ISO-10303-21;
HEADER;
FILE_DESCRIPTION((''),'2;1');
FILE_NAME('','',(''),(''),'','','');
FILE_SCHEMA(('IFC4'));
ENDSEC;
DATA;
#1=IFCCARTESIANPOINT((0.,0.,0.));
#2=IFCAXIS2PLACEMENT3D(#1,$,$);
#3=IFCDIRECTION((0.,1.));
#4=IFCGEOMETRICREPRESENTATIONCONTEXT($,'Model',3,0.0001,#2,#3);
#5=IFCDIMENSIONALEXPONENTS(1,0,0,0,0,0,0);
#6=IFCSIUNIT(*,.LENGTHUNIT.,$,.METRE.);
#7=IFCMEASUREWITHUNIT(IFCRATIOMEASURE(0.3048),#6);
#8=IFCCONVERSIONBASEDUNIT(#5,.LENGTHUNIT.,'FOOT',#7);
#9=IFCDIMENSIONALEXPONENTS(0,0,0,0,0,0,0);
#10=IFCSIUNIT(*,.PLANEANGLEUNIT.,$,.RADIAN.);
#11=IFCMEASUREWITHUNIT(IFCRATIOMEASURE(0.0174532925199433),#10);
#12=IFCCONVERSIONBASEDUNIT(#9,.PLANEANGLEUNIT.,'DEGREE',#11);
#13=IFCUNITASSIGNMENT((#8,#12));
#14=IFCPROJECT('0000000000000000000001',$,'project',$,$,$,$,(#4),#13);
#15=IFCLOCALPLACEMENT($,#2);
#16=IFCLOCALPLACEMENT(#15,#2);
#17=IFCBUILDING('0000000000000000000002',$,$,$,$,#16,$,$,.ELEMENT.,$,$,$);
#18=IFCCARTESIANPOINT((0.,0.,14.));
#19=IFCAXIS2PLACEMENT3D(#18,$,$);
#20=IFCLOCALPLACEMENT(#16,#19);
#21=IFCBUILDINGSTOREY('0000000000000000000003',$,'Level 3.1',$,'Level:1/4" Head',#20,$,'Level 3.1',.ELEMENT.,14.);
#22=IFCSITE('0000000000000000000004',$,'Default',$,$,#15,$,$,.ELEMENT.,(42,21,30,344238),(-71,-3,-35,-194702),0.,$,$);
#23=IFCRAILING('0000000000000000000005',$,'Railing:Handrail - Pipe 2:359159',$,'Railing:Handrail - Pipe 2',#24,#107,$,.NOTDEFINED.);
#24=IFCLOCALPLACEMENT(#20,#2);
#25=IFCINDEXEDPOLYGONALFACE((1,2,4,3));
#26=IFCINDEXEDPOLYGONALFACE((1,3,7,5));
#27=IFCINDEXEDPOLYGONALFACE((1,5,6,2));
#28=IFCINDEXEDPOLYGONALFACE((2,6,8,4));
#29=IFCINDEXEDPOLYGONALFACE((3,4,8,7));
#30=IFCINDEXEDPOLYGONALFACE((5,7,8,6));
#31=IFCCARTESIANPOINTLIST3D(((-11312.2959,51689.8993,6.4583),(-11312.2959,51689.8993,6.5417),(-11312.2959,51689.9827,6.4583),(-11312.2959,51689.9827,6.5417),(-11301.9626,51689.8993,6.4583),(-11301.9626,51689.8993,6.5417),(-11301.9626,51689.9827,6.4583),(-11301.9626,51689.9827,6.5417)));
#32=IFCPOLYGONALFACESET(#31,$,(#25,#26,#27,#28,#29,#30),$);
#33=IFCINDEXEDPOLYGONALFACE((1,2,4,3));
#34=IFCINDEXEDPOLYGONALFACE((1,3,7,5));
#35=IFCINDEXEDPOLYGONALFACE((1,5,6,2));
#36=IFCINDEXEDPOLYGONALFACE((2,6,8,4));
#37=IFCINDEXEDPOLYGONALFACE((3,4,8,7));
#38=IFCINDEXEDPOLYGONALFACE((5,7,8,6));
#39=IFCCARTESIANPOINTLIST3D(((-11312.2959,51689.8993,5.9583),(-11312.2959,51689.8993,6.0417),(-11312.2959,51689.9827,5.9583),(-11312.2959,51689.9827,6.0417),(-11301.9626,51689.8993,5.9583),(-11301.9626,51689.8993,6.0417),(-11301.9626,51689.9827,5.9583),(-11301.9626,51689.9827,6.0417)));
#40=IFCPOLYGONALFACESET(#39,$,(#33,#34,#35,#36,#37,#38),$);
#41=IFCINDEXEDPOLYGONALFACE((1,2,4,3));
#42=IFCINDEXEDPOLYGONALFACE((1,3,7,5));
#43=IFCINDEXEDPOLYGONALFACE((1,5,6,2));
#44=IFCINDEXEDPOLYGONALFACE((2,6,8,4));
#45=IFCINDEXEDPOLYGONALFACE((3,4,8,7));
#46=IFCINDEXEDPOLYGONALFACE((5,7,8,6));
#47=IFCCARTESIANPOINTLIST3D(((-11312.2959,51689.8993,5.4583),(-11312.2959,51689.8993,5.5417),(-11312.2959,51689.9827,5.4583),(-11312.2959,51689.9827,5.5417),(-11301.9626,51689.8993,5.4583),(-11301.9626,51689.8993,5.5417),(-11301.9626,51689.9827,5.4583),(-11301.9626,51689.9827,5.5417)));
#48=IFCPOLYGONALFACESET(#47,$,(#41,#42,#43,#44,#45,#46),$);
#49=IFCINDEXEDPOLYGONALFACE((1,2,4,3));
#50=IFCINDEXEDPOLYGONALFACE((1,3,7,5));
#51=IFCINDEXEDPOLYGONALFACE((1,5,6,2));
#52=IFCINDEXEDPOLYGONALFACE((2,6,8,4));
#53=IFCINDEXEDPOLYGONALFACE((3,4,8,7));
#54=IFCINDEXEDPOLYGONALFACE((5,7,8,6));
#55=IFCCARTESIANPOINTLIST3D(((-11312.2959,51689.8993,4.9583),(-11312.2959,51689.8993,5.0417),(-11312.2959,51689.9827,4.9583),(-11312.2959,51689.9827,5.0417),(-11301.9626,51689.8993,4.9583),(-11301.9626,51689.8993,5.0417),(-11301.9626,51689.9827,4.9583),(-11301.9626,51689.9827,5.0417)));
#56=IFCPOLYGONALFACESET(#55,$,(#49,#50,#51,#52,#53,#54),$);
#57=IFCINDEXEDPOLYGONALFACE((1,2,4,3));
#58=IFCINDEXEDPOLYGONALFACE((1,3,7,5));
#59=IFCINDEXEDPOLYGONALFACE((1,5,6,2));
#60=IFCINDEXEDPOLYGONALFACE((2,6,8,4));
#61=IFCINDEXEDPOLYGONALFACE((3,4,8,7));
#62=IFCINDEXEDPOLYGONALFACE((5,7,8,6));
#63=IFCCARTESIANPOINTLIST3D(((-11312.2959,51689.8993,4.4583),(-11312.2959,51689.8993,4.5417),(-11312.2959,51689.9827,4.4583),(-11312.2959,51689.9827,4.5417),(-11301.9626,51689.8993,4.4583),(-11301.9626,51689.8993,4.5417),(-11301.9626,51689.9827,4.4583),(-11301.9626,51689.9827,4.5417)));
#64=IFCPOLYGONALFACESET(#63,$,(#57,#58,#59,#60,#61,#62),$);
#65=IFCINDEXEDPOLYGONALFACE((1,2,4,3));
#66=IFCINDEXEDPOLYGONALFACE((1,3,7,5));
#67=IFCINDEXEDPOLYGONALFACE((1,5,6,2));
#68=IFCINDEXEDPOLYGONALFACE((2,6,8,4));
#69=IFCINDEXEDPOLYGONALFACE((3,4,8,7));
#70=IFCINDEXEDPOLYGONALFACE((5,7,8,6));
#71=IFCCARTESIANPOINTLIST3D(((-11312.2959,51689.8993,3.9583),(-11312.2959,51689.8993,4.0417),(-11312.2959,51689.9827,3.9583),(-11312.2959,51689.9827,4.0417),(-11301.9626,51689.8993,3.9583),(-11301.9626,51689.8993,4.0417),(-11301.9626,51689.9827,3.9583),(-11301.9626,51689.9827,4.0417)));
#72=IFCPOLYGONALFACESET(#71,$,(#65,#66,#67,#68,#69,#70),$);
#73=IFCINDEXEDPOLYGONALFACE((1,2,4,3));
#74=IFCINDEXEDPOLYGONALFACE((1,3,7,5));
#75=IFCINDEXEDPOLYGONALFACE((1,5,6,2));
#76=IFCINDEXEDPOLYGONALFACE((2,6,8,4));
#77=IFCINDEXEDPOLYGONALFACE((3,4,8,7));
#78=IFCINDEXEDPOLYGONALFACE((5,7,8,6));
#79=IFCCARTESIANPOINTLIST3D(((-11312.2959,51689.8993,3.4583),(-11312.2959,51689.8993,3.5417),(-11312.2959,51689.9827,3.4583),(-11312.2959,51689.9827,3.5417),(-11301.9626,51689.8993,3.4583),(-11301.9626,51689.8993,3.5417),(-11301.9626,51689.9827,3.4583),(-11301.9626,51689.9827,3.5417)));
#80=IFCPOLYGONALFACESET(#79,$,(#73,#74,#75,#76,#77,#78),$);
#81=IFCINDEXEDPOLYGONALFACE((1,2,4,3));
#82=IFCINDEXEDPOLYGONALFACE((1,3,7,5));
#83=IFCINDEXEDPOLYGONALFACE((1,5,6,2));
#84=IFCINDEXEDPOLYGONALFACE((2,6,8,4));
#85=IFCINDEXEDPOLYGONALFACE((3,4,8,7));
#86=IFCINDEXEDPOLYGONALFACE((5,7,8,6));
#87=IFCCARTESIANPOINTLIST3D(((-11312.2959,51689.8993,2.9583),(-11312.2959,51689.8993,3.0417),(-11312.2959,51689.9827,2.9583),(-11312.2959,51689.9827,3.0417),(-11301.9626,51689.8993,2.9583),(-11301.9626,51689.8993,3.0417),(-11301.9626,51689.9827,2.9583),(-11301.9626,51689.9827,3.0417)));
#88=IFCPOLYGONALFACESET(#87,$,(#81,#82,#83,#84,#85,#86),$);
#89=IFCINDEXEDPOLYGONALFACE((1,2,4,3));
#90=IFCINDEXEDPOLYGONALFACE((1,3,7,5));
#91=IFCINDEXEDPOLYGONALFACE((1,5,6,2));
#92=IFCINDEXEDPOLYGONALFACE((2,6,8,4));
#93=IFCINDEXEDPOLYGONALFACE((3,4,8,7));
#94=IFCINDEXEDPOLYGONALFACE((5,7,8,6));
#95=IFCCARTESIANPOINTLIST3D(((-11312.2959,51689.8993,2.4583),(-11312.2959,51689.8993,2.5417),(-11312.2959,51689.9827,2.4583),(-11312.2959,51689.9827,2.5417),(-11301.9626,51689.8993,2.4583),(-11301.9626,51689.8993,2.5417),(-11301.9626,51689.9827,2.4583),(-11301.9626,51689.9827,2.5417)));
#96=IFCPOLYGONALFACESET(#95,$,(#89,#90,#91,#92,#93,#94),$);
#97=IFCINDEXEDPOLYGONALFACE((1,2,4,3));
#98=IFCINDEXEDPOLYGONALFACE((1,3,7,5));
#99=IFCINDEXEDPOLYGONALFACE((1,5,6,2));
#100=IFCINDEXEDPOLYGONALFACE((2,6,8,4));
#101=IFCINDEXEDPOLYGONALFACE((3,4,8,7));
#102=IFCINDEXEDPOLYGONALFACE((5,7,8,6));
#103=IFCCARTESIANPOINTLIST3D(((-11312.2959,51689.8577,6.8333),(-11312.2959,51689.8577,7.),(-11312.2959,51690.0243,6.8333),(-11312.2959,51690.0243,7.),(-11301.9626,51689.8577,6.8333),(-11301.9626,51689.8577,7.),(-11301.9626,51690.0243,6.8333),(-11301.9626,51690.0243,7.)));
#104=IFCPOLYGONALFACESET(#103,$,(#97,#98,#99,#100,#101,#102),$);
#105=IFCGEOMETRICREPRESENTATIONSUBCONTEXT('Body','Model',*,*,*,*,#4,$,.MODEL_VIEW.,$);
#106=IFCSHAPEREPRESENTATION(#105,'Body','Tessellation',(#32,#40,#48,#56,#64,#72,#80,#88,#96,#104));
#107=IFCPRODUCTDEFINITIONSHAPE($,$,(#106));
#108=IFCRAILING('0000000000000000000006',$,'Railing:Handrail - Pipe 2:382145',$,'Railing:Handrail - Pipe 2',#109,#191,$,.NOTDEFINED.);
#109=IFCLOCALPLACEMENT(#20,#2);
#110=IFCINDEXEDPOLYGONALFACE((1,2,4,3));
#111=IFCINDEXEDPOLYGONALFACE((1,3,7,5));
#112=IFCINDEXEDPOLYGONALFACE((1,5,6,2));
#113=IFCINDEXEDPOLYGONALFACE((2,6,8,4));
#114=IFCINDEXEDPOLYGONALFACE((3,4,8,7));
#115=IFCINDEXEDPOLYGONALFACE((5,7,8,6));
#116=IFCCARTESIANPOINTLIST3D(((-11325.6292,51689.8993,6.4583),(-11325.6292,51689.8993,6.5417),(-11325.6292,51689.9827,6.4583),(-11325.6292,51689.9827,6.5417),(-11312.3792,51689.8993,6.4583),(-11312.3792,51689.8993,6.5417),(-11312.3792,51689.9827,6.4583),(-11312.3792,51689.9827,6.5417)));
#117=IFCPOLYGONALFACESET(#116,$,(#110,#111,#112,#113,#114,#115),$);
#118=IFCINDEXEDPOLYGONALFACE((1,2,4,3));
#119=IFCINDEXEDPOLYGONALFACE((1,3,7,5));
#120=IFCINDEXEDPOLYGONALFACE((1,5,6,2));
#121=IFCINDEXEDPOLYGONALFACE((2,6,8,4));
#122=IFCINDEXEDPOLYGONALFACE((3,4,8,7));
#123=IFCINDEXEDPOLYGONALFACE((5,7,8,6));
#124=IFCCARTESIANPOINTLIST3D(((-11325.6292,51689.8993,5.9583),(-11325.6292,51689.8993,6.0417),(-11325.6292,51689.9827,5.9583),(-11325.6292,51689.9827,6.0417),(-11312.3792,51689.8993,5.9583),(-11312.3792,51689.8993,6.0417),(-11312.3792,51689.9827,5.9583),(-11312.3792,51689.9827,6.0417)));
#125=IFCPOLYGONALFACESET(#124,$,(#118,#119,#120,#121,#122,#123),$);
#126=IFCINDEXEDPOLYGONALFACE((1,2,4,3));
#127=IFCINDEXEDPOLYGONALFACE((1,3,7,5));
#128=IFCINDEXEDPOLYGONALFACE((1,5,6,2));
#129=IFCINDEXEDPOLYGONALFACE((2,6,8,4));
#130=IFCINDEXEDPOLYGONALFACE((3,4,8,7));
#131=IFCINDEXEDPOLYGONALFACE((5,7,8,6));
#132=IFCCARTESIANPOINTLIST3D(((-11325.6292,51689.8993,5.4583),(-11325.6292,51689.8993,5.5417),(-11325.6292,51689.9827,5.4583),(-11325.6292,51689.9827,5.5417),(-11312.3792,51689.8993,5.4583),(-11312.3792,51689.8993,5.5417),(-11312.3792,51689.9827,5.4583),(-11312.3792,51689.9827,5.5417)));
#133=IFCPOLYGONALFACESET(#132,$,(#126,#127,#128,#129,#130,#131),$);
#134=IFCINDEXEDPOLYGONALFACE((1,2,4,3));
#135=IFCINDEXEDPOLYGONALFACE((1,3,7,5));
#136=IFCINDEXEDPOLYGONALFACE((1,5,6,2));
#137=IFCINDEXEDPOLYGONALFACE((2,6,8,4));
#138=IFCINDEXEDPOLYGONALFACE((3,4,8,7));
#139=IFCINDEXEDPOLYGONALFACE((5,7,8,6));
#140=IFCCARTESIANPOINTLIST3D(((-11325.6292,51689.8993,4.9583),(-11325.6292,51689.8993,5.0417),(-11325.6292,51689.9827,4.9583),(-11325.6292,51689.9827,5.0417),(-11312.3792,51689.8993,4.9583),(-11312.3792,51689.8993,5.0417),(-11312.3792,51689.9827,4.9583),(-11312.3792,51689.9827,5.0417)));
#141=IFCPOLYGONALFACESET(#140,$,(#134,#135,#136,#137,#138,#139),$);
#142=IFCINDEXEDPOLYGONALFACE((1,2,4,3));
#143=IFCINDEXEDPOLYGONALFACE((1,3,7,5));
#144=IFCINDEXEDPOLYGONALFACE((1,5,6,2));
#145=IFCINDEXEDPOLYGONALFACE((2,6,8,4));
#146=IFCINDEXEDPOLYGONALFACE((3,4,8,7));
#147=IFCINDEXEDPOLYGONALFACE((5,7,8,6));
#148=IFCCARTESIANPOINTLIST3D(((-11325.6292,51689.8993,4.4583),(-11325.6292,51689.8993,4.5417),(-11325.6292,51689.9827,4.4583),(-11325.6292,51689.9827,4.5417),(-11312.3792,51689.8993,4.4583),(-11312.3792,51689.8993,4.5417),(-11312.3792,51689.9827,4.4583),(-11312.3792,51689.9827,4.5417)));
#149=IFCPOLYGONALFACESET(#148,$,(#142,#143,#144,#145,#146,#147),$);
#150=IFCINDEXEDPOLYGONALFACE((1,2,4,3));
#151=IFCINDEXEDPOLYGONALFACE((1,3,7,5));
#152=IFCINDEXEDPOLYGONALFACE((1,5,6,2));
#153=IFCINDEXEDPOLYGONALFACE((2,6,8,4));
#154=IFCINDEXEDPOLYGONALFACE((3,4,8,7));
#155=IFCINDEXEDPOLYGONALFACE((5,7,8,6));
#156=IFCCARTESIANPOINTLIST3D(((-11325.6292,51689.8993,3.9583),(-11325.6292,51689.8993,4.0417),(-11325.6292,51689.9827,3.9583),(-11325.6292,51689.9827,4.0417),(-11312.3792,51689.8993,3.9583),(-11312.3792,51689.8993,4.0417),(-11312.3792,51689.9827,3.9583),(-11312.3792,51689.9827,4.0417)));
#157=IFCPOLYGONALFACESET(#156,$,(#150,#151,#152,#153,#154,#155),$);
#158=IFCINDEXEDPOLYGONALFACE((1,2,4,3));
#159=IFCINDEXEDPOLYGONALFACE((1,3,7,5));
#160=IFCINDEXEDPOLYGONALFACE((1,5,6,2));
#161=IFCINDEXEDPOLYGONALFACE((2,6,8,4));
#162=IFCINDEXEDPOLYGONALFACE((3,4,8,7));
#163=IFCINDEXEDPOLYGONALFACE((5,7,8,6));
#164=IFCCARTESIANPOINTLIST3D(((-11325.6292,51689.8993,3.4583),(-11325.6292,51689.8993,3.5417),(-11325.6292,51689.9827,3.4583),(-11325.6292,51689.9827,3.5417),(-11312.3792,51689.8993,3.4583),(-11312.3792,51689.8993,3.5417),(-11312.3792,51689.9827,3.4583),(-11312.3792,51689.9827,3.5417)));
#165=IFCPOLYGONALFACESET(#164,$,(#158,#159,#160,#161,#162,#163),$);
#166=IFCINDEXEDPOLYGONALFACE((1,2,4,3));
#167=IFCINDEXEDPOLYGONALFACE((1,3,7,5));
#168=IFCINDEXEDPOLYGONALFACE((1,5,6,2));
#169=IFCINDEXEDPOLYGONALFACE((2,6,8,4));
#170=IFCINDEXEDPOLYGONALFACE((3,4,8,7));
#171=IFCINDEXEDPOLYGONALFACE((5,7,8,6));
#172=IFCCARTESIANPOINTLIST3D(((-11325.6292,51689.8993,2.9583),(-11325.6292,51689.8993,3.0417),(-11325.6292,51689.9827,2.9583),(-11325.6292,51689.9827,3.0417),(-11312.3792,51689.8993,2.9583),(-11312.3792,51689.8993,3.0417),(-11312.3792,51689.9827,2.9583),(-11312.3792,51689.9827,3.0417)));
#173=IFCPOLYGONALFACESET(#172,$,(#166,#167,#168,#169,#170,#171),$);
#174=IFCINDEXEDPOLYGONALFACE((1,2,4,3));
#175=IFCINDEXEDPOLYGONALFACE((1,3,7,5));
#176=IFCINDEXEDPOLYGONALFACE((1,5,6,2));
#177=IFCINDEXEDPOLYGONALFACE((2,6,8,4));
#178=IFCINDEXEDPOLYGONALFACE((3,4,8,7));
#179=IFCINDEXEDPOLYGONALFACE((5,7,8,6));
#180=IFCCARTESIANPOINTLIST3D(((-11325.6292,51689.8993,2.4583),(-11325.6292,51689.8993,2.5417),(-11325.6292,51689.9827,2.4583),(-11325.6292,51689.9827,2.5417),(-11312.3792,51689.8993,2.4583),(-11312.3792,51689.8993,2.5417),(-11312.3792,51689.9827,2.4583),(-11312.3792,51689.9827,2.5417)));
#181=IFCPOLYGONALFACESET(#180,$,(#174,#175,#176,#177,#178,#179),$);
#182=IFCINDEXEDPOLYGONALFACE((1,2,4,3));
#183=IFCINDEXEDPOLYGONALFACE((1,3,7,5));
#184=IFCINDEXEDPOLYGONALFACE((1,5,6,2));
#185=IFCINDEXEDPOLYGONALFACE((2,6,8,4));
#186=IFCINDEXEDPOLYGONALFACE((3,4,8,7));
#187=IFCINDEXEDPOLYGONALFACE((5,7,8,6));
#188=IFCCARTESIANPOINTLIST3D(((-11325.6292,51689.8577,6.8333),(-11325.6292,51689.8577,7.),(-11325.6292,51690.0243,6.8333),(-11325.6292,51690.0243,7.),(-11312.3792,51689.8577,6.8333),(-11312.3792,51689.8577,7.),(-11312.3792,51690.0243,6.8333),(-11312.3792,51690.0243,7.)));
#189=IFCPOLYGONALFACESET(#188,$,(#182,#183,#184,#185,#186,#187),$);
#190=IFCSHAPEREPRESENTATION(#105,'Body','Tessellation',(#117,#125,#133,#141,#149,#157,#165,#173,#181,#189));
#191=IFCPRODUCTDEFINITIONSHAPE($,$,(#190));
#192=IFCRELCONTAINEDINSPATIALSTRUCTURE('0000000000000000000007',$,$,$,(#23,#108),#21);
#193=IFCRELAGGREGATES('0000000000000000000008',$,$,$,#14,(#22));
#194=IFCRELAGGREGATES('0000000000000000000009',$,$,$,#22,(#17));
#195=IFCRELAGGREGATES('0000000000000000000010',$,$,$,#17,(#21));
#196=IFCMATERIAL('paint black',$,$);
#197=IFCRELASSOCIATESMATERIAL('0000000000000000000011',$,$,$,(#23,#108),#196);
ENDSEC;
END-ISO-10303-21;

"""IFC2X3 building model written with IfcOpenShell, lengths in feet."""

from ifc_helpers import new_model, entity, si_unit, converted_unit, direction, frame, frame_2d, origin, place, context, subcontext, project, spatial, rectangle, extrude, material, element, save


model = new_model("IFC2X3")

# Units and contexts
model_context = context("Model", 3, precision=0.0001, world=origin(), true_north=direction((0.0, 1.0)))
body_context = subcontext(model_context, "Body", "Model", "MODEL_VIEW")
ifc_project = project(units=[converted_unit("LENGTHUNIT", "FOOT", entity("IfcRatioMeasure", 0.3048), si_unit("LENGTHUNIT", "METRE"), dimensions=[1, 0, 0, 0, 0, 0, 0]), converted_unit("PLANEANGLEUNIT", "DEGREE", entity("IfcRatioMeasure", 0.0174532925199433), si_unit("PLANEANGLEUNIT", "RADIAN"), dimensions=[0, 0, 0, 0, 0, 0, 0])], contexts=[model_context])

# Site, building, storey
site_placement = place(None, origin())
site = spatial("IfcSite", under=ifc_project, at=site_placement, Name="Default", CompositionType="ELEMENT", RefLatitude=(42, 21, 30, 344238), RefLongitude=(-71, -3, -35, -194702), RefElevation=0.0)
building_placement = place(site_placement, origin())
building = spatial("IfcBuilding", under=site, at=building_placement, CompositionType="ELEMENT")
storey_placement = place(building_placement, frame((0.0, 0.0, 14.0)))
storey = spatial("IfcBuildingStorey", under=building, at=storey_placement, Name="Level 3.1", ObjectType="Level:1/4\" Head", LongName="Level 3.1", CompositionType="ELEMENT", Elevation=14.0)

# Railings
ifc_material_1 = material(Name="paint black")
railing_1_placement = place(storey_placement, origin())
element("IfcRailing", 1, at=railing_1_placement, inside=storey, material=ifc_material_1, Name="Railing:Handrail - Pipe 2:359159", ObjectType="Railing:Handrail - Pipe 2", PredefinedType="NOTDEFINED", context=body_context, shape_type="SweptSolid", body=[
    extrude(rectangle(XDim=10.3333, YDim=0.0833, at=frame_2d((0.0, 0.0), x_axis=(1.0, 0.0))), frame((-11307.1292, 51689.941, 6.4583), z_axis=(0.0, 0.0, 1.0), x_axis=(-1.0, 0.0, 0.0)), (0.0, 0.0, 1.0), 0.0833),
    extrude(rectangle(XDim=10.3333, YDim=0.0833, at=frame_2d((0.0, 0.0), x_axis=(1.0, 0.0))), frame((-11307.1292, 51689.941, 5.9583), z_axis=(0.0, 0.0, 1.0), x_axis=(-1.0, 0.0, 0.0)), (0.0, 0.0, 1.0), 0.0833),
    extrude(rectangle(XDim=10.3333, YDim=0.0833, at=frame_2d((0.0, 0.0), x_axis=(1.0, 0.0))), frame((-11307.1292, 51689.941, 5.4583), z_axis=(0.0, 0.0, 1.0), x_axis=(-1.0, 0.0, 0.0)), (0.0, 0.0, 1.0), 0.0833),
    extrude(rectangle(XDim=10.3333, YDim=0.0833, at=frame_2d((0.0, 0.0), x_axis=(1.0, 0.0))), frame((-11307.1292, 51689.941, 4.9583), z_axis=(0.0, 0.0, 1.0), x_axis=(-1.0, 0.0, 0.0)), (0.0, 0.0, 1.0), 0.0833),
    extrude(rectangle(XDim=10.3333, YDim=0.0833, at=frame_2d((0.0, 0.0), x_axis=(1.0, 0.0))), frame((-11307.1292, 51689.941, 4.4583), z_axis=(0.0, 0.0, 1.0), x_axis=(-1.0, 0.0, 0.0)), (0.0, 0.0, 1.0), 0.0833),
    extrude(rectangle(XDim=10.3333, YDim=0.0833, at=frame_2d((0.0, 0.0), x_axis=(1.0, 0.0))), frame((-11307.1292, 51689.941, 3.9583), z_axis=(0.0, 0.0, 1.0), x_axis=(-1.0, 0.0, 0.0)), (0.0, 0.0, 1.0), 0.0833),
    extrude(rectangle(XDim=10.3333, YDim=0.0833, at=frame_2d((0.0, 0.0), x_axis=(1.0, 0.0))), frame((-11307.1292, 51689.941, 3.4583), z_axis=(0.0, 0.0, 1.0), x_axis=(-1.0, 0.0, 0.0)), (0.0, 0.0, 1.0), 0.0833),
    extrude(rectangle(XDim=10.3333, YDim=0.0833, at=frame_2d((0.0, 0.0), x_axis=(1.0, 0.0))), frame((-11307.1292, 51689.941, 2.9583), z_axis=(0.0, 0.0, 1.0), x_axis=(-1.0, 0.0, 0.0)), (0.0, 0.0, 1.0), 0.0833),
    extrude(rectangle(XDim=10.3333, YDim=0.0833, at=frame_2d((0.0, 0.0), x_axis=(1.0, 0.0))), frame((-11307.1292, 51689.941, 2.4583), z_axis=(0.0, 0.0, 1.0), x_axis=(-1.0, 0.0, 0.0)), (0.0, 0.0, 1.0), 0.0833),
    extrude(rectangle(XDim=10.3333, YDim=0.1667, at=frame_2d((0.0, 0.0), x_axis=(1.0, 0.0))), frame((-11307.1292, 51689.941, 6.8333), z_axis=(0.0, 0.0, 1.0), x_axis=(-1.0, 0.0, 0.0)), (0.0, 0.0, 1.0), 0.1667),
])
railing_2_placement = place(storey_placement, origin())
element("IfcRailing", 2, at=railing_2_placement, inside=storey, material=ifc_material_1, Name="Railing:Handrail - Pipe 2:382145", ObjectType="Railing:Handrail - Pipe 2", PredefinedType="NOTDEFINED", context=body_context, shape_type="SweptSolid", body=[
    extrude(rectangle(XDim=13.25, YDim=0.0833, at=frame_2d((0.0, 0.0), x_axis=(1.0, 0.0))), frame((-11319.0042, 51689.941, 6.4583), z_axis=(0.0, 0.0, 1.0), x_axis=(-1.0, 0.0, 0.0)), (0.0, 0.0, 1.0), 0.0833),
    extrude(rectangle(XDim=13.25, YDim=0.0833, at=frame_2d((0.0, 0.0), x_axis=(1.0, 0.0))), frame((-11319.0042, 51689.941, 5.9583), z_axis=(0.0, 0.0, 1.0), x_axis=(-1.0, 0.0, 0.0)), (0.0, 0.0, 1.0), 0.0833),
    extrude(rectangle(XDim=13.25, YDim=0.0833, at=frame_2d((0.0, 0.0), x_axis=(1.0, 0.0))), frame((-11319.0042, 51689.941, 5.4583), z_axis=(0.0, 0.0, 1.0), x_axis=(-1.0, 0.0, 0.0)), (0.0, 0.0, 1.0), 0.0833),
    extrude(rectangle(XDim=13.25, YDim=0.0833, at=frame_2d((0.0, 0.0), x_axis=(1.0, 0.0))), frame((-11319.0042, 51689.941, 4.9583), z_axis=(0.0, 0.0, 1.0), x_axis=(-1.0, 0.0, 0.0)), (0.0, 0.0, 1.0), 0.0833),
    extrude(rectangle(XDim=13.25, YDim=0.0833, at=frame_2d((0.0, 0.0), x_axis=(1.0, 0.0))), frame((-11319.0042, 51689.941, 4.4583), z_axis=(0.0, 0.0, 1.0), x_axis=(-1.0, 0.0, 0.0)), (0.0, 0.0, 1.0), 0.0833),
    extrude(rectangle(XDim=13.25, YDim=0.0833, at=frame_2d((0.0, 0.0), x_axis=(1.0, 0.0))), frame((-11319.0042, 51689.941, 3.9583), z_axis=(0.0, 0.0, 1.0), x_axis=(-1.0, 0.0, 0.0)), (0.0, 0.0, 1.0), 0.0833),
    extrude(rectangle(XDim=13.25, YDim=0.0833, at=frame_2d((0.0, 0.0), x_axis=(1.0, 0.0))), frame((-11319.0042, 51689.941, 3.4583), z_axis=(0.0, 0.0, 1.0), x_axis=(-1.0, 0.0, 0.0)), (0.0, 0.0, 1.0), 0.0833),
    extrude(rectangle(XDim=13.25, YDim=0.0833, at=frame_2d((0.0, 0.0), x_axis=(1.0, 0.0))), frame((-11319.0042, 51689.941, 2.9583), z_axis=(0.0, 0.0, 1.0), x_axis=(-1.0, 0.0, 0.0)), (0.0, 0.0, 1.0), 0.0833),
    extrude(rectangle(XDim=13.25, YDim=0.0833, at=frame_2d((0.0, 0.0), x_axis=(1.0, 0.0))), frame((-11319.0042, 51689.941, 2.4583), z_axis=(0.0, 0.0, 1.0), x_axis=(-1.0, 0.0, 0.0)), (0.0, 0.0, 1.0), 0.0833),
    extrude(rectangle(XDim=13.25, YDim=0.1667, at=frame_2d((0.0, 0.0), x_axis=(1.0, 0.0))), frame((-11319.0042, 51689.941, 6.8333), z_axis=(0.0, 0.0, 1.0), x_axis=(-1.0, 0.0, 0.0)), (0.0, 0.0, 1.0), 0.1667),
])

save(model, "model.ifc")
